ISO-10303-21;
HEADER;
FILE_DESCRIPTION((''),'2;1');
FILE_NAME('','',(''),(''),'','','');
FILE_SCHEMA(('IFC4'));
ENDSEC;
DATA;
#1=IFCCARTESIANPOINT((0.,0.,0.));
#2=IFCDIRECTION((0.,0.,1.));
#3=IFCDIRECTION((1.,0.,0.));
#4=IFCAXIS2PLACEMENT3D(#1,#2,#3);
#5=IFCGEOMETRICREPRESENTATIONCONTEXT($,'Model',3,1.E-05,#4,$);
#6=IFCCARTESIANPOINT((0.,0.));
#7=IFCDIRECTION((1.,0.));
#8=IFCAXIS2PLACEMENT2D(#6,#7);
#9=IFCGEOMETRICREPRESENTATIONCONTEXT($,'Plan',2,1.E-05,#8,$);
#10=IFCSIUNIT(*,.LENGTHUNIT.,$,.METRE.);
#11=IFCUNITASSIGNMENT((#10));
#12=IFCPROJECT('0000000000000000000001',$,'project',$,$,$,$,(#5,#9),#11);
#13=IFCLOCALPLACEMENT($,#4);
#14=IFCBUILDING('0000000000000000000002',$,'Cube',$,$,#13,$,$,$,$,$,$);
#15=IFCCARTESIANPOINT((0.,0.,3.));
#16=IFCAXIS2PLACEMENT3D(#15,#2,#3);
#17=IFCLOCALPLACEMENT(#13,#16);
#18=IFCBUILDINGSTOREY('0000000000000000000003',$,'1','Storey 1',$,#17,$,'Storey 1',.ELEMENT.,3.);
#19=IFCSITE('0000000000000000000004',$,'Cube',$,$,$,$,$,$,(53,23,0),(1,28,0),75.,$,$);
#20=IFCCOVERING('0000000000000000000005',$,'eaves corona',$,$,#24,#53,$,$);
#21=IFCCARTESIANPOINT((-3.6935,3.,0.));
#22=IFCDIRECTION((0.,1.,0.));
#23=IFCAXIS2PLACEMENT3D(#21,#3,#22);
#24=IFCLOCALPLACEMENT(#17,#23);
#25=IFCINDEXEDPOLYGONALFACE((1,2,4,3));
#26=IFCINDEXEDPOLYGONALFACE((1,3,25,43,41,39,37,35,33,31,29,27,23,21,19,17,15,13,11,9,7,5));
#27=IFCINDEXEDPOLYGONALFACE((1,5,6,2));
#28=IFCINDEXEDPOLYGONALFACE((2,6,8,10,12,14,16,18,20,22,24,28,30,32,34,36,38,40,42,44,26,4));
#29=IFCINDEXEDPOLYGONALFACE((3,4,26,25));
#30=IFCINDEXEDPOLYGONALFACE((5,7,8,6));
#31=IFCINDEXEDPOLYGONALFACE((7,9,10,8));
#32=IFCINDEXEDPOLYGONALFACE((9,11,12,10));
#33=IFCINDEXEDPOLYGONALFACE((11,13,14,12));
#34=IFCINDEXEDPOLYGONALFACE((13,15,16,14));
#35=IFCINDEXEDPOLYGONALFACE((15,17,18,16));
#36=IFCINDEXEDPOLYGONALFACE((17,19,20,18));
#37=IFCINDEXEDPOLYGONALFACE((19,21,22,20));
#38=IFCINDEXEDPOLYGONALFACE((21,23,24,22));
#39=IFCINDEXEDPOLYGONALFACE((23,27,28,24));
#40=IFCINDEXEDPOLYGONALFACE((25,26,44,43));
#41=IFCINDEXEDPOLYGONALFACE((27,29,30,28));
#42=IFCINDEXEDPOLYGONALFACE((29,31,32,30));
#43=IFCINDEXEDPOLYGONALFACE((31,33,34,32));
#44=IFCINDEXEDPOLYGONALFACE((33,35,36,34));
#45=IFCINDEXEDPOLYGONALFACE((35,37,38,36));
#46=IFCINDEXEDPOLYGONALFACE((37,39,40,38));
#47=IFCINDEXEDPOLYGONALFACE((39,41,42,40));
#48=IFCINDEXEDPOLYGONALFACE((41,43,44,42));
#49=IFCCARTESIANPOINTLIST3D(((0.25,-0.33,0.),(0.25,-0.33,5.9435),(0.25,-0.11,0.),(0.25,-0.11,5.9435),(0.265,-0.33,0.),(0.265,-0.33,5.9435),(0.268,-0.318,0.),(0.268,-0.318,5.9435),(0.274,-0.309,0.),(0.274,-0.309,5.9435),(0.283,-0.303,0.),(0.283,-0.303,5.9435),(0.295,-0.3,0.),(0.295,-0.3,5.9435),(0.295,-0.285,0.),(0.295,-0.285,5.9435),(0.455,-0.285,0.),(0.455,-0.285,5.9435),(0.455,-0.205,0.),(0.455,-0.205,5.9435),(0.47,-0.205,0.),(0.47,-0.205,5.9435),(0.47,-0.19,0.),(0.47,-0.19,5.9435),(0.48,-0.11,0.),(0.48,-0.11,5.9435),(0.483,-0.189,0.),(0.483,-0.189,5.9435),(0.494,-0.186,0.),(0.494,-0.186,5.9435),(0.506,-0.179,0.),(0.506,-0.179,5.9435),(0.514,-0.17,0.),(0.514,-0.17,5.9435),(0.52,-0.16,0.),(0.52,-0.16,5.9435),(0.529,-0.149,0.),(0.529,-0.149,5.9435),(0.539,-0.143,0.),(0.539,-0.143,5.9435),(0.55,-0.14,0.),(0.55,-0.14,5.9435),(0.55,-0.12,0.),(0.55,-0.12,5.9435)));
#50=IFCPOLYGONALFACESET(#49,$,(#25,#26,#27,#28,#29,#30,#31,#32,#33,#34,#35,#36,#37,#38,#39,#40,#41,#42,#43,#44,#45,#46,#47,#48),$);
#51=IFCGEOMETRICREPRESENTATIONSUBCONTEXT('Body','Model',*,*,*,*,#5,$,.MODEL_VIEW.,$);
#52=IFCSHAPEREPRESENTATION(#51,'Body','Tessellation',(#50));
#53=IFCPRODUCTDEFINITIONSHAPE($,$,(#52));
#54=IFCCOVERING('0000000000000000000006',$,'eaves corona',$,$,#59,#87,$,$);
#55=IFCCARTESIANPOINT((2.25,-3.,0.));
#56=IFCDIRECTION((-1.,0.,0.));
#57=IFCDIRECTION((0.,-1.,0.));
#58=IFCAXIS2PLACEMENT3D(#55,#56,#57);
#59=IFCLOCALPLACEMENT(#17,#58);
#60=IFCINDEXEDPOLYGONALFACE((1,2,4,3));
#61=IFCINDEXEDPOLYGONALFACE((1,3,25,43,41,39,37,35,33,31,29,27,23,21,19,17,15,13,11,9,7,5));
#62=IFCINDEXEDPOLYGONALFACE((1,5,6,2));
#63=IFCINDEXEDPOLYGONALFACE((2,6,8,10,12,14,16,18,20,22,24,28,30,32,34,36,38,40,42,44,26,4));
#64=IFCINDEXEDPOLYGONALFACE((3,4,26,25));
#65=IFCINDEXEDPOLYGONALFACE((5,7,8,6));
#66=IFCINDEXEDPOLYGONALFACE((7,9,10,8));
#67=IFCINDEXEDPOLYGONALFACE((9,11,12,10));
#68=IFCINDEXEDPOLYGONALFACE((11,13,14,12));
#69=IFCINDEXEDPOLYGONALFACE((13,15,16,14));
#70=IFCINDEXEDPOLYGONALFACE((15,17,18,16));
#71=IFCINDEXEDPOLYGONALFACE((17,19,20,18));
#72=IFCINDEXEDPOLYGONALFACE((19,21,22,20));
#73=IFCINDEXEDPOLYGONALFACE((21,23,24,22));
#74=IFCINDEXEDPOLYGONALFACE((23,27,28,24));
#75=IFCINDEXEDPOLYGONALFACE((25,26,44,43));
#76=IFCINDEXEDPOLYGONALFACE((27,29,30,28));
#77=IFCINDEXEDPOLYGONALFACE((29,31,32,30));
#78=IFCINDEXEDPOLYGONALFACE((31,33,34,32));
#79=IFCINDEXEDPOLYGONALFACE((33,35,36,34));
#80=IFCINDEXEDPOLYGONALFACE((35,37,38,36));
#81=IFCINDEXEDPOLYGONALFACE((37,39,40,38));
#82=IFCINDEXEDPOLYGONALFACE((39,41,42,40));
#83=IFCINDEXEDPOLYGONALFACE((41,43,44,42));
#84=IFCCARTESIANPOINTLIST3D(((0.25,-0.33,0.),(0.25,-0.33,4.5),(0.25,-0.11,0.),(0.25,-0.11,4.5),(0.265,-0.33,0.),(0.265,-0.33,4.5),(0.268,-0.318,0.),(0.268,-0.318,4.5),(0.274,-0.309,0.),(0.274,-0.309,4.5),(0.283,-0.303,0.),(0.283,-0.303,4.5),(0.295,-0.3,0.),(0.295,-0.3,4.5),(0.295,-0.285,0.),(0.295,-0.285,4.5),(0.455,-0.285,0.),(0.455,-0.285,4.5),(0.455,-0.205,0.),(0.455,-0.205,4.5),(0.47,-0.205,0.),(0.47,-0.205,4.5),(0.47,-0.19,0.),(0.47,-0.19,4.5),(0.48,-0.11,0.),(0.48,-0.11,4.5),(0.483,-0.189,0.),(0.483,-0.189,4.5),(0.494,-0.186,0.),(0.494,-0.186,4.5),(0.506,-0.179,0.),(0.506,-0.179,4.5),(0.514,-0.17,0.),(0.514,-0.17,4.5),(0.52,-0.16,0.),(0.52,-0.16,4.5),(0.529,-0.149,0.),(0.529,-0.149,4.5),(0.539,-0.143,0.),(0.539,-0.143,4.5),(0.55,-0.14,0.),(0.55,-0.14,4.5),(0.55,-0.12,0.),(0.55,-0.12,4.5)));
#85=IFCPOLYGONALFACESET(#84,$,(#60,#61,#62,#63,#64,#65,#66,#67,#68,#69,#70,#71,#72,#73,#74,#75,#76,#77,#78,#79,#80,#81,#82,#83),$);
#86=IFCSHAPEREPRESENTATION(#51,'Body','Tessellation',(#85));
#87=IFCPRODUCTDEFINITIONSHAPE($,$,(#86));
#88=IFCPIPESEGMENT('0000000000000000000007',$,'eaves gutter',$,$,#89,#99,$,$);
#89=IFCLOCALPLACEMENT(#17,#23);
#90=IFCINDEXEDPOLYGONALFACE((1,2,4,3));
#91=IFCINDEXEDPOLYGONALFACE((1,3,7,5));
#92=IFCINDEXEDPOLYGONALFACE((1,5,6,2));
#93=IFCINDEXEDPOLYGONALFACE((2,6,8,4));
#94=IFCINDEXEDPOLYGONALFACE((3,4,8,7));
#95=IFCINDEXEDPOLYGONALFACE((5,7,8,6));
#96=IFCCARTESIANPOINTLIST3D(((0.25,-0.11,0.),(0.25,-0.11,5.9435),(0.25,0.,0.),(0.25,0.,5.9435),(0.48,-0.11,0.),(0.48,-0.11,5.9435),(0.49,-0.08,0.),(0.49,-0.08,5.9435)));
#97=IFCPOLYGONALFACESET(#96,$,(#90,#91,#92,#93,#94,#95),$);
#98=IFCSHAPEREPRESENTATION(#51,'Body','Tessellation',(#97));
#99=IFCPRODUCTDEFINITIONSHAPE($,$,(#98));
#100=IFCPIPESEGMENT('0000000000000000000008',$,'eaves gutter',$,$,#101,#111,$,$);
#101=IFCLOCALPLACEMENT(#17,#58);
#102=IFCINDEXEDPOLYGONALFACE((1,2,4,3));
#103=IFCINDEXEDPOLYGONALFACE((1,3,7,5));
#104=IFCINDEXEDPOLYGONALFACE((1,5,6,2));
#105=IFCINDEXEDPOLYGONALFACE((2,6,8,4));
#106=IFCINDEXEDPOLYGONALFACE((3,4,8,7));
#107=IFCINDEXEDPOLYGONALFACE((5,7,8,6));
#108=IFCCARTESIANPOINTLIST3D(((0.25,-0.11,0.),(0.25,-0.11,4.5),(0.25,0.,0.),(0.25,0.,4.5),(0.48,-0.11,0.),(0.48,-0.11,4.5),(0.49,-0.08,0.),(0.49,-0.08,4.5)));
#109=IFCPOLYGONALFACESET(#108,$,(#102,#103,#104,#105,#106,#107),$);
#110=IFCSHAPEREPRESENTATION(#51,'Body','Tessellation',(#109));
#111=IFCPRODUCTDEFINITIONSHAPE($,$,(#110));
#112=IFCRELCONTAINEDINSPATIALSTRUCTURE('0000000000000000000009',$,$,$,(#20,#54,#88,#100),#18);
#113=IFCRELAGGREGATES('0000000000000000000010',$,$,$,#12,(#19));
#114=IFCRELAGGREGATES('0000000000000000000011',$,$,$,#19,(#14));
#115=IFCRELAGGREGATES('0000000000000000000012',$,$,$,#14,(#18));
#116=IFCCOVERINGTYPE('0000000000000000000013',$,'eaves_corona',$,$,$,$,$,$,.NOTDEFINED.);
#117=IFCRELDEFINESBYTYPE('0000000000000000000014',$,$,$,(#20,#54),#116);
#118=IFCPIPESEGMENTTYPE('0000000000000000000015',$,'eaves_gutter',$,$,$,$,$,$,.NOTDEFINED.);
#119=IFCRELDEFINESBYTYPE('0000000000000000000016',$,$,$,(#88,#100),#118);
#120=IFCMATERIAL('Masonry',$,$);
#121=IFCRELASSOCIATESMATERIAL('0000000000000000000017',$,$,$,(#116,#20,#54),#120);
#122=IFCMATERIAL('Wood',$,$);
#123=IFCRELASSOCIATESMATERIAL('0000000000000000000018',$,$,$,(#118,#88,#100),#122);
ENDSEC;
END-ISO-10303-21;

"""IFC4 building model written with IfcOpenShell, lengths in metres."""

from ifc_helpers import new_model, si_unit, frame, origin_with_axes, origin_2d_with_axis, place, context, subcontext, project, spatial, polyline, outline, extrude, material, material_profile, profile_set, profile_usage, type_object, element, save


model = new_model("IFC4")

# Units and contexts
model_context = context("Model", 3, precision=1e-05, world=origin_with_axes())
plan_context = context("Plan", 2, precision=1e-05, world=origin_2d_with_axis())
body_context = subcontext(model_context, "Body", "Model", "MODEL_VIEW")
ifc_project = project(units=[si_unit("LENGTHUNIT", "METRE")], contexts=[model_context, plan_context])

# Site, building, storey
site = spatial("IfcSite", under=ifc_project, Name="Cube", RefLatitude=(53, 23, 0), RefLongitude=(1, 28, 0), RefElevation=75.0)
building_placement = place(None, origin_with_axes())
building = spatial("IfcBuilding", under=site, at=building_placement, Name="Cube")
storey_placement = place(building_placement, frame((0.0, 0.0, 3.0), z_axis=(0.0, 0.0, 1.0), x_axis=(1.0, 0.0, 0.0)))
storey = spatial("IfcBuildingStorey", under=building, at=storey_placement, Name="1", Description="Storey 1", LongName="Storey 1", CompositionType="ELEMENT", Elevation=3.0)

# Coverings
ifc_material_1 = material(Name="Masonry")
ifc_material_profile_1 = material_profile(ifc_material_1, outline(polyline([(0.25, -0.11), (0.25, -0.33), (0.265, -0.33), (0.268, -0.318), (0.274, -0.309), (0.283, -0.303), (0.295, -0.3), (0.295, -0.285), (0.455, -0.285), (0.455, -0.205), (0.47, -0.205), (0.47, -0.19), (0.483, -0.189), (0.494, -0.186), (0.506, -0.179), (0.514, -0.17), (0.52, -0.16), (0.529, -0.149), (0.539, -0.143), (0.55, -0.14), (0.55, -0.12), (0.48, -0.11), (0.25, -0.11)])))
ifc_profile_set_1 = profile_set([ifc_material_profile_1])
ifc_profile_usage_1 = profile_usage(ifc_profile_set_1)
covering_type_1 = type_object("IfcCoveringType", Name="eaves_corona", PredefinedType="NOTDEFINED", material=ifc_profile_set_1)
covering_1_placement = place(storey_placement, frame((-3.6935, 3.0, 0.0), z_axis=(1.0, 0.0, 0.0), x_axis=(0.0, 1.0, 0.0)))
element("IfcCovering", 1, at=covering_1_placement, inside=storey, type_object=covering_type_1, material=ifc_profile_usage_1, Name="eaves corona", context=body_context, shape_type="SweptSolid", body=[
    extrude(outline(polyline([(0.25, -0.11), (0.25, -0.33), (0.265, -0.33), (0.268, -0.318), (0.274, -0.309), (0.283, -0.303), (0.295, -0.3), (0.295, -0.285), (0.455, -0.285), (0.455, -0.205), (0.47, -0.205), (0.47, -0.19), (0.483, -0.189), (0.494, -0.186), (0.506, -0.179), (0.514, -0.17), (0.52, -0.16), (0.529, -0.149), (0.539, -0.143), (0.55, -0.14), (0.55, -0.12), (0.48, -0.11), (0.25, -0.11)])), origin_with_axes(), (0.0, 0.0, 1.0), 5.9435),
])
ifc_profile_usage_2 = profile_usage(ifc_profile_set_1)
covering_2_placement = place(storey_placement, frame((2.25, -3.0, 0.0), z_axis=(-1.0, 0.0, 0.0), x_axis=(0.0, -1.0, 0.0)))
element("IfcCovering", 2, at=covering_2_placement, inside=storey, type_object=covering_type_1, material=ifc_profile_usage_2, Name="eaves corona", context=body_context, shape_type="SweptSolid", body=[
    extrude(outline(polyline([(0.25, -0.11), (0.25, -0.33), (0.265, -0.33), (0.268, -0.318), (0.274, -0.309), (0.283, -0.303), (0.295, -0.3), (0.295, -0.285), (0.455, -0.285), (0.455, -0.205), (0.47, -0.205), (0.47, -0.19), (0.483, -0.189), (0.494, -0.186), (0.506, -0.179), (0.514, -0.17), (0.52, -0.16), (0.529, -0.149), (0.539, -0.143), (0.55, -0.14), (0.55, -0.12), (0.48, -0.11), (0.25, -0.11)])), origin_with_axes(), (0.0, 0.0, 1.0), 4.5),
])

# Pipe segments
ifc_material_2 = material(Name="Wood")
ifc_material_profile_2 = material_profile(ifc_material_2, outline(polyline([(0.25, -0.11), (0.48, -0.11), (0.49, -0.08), (0.25, 0.0), (0.25, -0.11)])))
ifc_profile_set_2 = profile_set([ifc_material_profile_2])
ifc_profile_usage_3 = profile_usage(ifc_profile_set_2)
pipe_segment_type = type_object("IfcPipeSegmentType", Name="eaves_gutter", PredefinedType="NOTDEFINED", material=ifc_profile_set_2)
pipe_segment_1_placement = place(storey_placement, frame((-3.6935, 3.0, 0.0), z_axis=(1.0, 0.0, 0.0), x_axis=(0.0, 1.0, 0.0)))
element("IfcPipeSegment", 3, at=pipe_segment_1_placement, inside=storey, type_object=pipe_segment_type, material=ifc_profile_usage_3, Name="eaves gutter", context=body_context, shape_type="SweptSolid", body=[
    extrude(outline(polyline([(0.25, -0.11), (0.48, -0.11), (0.49, -0.08), (0.25, 0.0), (0.25, -0.11)])), origin_with_axes(), (0.0, 0.0, 1.0), 5.9435),
])
ifc_profile_usage_4 = profile_usage(ifc_profile_set_2)
pipe_segment_2_placement = place(storey_placement, frame((2.25, -3.0, 0.0), z_axis=(-1.0, 0.0, 0.0), x_axis=(0.0, -1.0, 0.0)))
element("IfcPipeSegment", 4, at=pipe_segment_2_placement, inside=storey, type_object=pipe_segment_type, material=ifc_profile_usage_4, Name="eaves gutter", context=body_context, shape_type="SweptSolid", body=[
    extrude(outline(polyline([(0.25, -0.11), (0.48, -0.11), (0.49, -0.08), (0.25, 0.0), (0.25, -0.11)])), origin_with_axes(), (0.0, 0.0, 1.0), 4.5),
])

save(model, "model.ifc")
